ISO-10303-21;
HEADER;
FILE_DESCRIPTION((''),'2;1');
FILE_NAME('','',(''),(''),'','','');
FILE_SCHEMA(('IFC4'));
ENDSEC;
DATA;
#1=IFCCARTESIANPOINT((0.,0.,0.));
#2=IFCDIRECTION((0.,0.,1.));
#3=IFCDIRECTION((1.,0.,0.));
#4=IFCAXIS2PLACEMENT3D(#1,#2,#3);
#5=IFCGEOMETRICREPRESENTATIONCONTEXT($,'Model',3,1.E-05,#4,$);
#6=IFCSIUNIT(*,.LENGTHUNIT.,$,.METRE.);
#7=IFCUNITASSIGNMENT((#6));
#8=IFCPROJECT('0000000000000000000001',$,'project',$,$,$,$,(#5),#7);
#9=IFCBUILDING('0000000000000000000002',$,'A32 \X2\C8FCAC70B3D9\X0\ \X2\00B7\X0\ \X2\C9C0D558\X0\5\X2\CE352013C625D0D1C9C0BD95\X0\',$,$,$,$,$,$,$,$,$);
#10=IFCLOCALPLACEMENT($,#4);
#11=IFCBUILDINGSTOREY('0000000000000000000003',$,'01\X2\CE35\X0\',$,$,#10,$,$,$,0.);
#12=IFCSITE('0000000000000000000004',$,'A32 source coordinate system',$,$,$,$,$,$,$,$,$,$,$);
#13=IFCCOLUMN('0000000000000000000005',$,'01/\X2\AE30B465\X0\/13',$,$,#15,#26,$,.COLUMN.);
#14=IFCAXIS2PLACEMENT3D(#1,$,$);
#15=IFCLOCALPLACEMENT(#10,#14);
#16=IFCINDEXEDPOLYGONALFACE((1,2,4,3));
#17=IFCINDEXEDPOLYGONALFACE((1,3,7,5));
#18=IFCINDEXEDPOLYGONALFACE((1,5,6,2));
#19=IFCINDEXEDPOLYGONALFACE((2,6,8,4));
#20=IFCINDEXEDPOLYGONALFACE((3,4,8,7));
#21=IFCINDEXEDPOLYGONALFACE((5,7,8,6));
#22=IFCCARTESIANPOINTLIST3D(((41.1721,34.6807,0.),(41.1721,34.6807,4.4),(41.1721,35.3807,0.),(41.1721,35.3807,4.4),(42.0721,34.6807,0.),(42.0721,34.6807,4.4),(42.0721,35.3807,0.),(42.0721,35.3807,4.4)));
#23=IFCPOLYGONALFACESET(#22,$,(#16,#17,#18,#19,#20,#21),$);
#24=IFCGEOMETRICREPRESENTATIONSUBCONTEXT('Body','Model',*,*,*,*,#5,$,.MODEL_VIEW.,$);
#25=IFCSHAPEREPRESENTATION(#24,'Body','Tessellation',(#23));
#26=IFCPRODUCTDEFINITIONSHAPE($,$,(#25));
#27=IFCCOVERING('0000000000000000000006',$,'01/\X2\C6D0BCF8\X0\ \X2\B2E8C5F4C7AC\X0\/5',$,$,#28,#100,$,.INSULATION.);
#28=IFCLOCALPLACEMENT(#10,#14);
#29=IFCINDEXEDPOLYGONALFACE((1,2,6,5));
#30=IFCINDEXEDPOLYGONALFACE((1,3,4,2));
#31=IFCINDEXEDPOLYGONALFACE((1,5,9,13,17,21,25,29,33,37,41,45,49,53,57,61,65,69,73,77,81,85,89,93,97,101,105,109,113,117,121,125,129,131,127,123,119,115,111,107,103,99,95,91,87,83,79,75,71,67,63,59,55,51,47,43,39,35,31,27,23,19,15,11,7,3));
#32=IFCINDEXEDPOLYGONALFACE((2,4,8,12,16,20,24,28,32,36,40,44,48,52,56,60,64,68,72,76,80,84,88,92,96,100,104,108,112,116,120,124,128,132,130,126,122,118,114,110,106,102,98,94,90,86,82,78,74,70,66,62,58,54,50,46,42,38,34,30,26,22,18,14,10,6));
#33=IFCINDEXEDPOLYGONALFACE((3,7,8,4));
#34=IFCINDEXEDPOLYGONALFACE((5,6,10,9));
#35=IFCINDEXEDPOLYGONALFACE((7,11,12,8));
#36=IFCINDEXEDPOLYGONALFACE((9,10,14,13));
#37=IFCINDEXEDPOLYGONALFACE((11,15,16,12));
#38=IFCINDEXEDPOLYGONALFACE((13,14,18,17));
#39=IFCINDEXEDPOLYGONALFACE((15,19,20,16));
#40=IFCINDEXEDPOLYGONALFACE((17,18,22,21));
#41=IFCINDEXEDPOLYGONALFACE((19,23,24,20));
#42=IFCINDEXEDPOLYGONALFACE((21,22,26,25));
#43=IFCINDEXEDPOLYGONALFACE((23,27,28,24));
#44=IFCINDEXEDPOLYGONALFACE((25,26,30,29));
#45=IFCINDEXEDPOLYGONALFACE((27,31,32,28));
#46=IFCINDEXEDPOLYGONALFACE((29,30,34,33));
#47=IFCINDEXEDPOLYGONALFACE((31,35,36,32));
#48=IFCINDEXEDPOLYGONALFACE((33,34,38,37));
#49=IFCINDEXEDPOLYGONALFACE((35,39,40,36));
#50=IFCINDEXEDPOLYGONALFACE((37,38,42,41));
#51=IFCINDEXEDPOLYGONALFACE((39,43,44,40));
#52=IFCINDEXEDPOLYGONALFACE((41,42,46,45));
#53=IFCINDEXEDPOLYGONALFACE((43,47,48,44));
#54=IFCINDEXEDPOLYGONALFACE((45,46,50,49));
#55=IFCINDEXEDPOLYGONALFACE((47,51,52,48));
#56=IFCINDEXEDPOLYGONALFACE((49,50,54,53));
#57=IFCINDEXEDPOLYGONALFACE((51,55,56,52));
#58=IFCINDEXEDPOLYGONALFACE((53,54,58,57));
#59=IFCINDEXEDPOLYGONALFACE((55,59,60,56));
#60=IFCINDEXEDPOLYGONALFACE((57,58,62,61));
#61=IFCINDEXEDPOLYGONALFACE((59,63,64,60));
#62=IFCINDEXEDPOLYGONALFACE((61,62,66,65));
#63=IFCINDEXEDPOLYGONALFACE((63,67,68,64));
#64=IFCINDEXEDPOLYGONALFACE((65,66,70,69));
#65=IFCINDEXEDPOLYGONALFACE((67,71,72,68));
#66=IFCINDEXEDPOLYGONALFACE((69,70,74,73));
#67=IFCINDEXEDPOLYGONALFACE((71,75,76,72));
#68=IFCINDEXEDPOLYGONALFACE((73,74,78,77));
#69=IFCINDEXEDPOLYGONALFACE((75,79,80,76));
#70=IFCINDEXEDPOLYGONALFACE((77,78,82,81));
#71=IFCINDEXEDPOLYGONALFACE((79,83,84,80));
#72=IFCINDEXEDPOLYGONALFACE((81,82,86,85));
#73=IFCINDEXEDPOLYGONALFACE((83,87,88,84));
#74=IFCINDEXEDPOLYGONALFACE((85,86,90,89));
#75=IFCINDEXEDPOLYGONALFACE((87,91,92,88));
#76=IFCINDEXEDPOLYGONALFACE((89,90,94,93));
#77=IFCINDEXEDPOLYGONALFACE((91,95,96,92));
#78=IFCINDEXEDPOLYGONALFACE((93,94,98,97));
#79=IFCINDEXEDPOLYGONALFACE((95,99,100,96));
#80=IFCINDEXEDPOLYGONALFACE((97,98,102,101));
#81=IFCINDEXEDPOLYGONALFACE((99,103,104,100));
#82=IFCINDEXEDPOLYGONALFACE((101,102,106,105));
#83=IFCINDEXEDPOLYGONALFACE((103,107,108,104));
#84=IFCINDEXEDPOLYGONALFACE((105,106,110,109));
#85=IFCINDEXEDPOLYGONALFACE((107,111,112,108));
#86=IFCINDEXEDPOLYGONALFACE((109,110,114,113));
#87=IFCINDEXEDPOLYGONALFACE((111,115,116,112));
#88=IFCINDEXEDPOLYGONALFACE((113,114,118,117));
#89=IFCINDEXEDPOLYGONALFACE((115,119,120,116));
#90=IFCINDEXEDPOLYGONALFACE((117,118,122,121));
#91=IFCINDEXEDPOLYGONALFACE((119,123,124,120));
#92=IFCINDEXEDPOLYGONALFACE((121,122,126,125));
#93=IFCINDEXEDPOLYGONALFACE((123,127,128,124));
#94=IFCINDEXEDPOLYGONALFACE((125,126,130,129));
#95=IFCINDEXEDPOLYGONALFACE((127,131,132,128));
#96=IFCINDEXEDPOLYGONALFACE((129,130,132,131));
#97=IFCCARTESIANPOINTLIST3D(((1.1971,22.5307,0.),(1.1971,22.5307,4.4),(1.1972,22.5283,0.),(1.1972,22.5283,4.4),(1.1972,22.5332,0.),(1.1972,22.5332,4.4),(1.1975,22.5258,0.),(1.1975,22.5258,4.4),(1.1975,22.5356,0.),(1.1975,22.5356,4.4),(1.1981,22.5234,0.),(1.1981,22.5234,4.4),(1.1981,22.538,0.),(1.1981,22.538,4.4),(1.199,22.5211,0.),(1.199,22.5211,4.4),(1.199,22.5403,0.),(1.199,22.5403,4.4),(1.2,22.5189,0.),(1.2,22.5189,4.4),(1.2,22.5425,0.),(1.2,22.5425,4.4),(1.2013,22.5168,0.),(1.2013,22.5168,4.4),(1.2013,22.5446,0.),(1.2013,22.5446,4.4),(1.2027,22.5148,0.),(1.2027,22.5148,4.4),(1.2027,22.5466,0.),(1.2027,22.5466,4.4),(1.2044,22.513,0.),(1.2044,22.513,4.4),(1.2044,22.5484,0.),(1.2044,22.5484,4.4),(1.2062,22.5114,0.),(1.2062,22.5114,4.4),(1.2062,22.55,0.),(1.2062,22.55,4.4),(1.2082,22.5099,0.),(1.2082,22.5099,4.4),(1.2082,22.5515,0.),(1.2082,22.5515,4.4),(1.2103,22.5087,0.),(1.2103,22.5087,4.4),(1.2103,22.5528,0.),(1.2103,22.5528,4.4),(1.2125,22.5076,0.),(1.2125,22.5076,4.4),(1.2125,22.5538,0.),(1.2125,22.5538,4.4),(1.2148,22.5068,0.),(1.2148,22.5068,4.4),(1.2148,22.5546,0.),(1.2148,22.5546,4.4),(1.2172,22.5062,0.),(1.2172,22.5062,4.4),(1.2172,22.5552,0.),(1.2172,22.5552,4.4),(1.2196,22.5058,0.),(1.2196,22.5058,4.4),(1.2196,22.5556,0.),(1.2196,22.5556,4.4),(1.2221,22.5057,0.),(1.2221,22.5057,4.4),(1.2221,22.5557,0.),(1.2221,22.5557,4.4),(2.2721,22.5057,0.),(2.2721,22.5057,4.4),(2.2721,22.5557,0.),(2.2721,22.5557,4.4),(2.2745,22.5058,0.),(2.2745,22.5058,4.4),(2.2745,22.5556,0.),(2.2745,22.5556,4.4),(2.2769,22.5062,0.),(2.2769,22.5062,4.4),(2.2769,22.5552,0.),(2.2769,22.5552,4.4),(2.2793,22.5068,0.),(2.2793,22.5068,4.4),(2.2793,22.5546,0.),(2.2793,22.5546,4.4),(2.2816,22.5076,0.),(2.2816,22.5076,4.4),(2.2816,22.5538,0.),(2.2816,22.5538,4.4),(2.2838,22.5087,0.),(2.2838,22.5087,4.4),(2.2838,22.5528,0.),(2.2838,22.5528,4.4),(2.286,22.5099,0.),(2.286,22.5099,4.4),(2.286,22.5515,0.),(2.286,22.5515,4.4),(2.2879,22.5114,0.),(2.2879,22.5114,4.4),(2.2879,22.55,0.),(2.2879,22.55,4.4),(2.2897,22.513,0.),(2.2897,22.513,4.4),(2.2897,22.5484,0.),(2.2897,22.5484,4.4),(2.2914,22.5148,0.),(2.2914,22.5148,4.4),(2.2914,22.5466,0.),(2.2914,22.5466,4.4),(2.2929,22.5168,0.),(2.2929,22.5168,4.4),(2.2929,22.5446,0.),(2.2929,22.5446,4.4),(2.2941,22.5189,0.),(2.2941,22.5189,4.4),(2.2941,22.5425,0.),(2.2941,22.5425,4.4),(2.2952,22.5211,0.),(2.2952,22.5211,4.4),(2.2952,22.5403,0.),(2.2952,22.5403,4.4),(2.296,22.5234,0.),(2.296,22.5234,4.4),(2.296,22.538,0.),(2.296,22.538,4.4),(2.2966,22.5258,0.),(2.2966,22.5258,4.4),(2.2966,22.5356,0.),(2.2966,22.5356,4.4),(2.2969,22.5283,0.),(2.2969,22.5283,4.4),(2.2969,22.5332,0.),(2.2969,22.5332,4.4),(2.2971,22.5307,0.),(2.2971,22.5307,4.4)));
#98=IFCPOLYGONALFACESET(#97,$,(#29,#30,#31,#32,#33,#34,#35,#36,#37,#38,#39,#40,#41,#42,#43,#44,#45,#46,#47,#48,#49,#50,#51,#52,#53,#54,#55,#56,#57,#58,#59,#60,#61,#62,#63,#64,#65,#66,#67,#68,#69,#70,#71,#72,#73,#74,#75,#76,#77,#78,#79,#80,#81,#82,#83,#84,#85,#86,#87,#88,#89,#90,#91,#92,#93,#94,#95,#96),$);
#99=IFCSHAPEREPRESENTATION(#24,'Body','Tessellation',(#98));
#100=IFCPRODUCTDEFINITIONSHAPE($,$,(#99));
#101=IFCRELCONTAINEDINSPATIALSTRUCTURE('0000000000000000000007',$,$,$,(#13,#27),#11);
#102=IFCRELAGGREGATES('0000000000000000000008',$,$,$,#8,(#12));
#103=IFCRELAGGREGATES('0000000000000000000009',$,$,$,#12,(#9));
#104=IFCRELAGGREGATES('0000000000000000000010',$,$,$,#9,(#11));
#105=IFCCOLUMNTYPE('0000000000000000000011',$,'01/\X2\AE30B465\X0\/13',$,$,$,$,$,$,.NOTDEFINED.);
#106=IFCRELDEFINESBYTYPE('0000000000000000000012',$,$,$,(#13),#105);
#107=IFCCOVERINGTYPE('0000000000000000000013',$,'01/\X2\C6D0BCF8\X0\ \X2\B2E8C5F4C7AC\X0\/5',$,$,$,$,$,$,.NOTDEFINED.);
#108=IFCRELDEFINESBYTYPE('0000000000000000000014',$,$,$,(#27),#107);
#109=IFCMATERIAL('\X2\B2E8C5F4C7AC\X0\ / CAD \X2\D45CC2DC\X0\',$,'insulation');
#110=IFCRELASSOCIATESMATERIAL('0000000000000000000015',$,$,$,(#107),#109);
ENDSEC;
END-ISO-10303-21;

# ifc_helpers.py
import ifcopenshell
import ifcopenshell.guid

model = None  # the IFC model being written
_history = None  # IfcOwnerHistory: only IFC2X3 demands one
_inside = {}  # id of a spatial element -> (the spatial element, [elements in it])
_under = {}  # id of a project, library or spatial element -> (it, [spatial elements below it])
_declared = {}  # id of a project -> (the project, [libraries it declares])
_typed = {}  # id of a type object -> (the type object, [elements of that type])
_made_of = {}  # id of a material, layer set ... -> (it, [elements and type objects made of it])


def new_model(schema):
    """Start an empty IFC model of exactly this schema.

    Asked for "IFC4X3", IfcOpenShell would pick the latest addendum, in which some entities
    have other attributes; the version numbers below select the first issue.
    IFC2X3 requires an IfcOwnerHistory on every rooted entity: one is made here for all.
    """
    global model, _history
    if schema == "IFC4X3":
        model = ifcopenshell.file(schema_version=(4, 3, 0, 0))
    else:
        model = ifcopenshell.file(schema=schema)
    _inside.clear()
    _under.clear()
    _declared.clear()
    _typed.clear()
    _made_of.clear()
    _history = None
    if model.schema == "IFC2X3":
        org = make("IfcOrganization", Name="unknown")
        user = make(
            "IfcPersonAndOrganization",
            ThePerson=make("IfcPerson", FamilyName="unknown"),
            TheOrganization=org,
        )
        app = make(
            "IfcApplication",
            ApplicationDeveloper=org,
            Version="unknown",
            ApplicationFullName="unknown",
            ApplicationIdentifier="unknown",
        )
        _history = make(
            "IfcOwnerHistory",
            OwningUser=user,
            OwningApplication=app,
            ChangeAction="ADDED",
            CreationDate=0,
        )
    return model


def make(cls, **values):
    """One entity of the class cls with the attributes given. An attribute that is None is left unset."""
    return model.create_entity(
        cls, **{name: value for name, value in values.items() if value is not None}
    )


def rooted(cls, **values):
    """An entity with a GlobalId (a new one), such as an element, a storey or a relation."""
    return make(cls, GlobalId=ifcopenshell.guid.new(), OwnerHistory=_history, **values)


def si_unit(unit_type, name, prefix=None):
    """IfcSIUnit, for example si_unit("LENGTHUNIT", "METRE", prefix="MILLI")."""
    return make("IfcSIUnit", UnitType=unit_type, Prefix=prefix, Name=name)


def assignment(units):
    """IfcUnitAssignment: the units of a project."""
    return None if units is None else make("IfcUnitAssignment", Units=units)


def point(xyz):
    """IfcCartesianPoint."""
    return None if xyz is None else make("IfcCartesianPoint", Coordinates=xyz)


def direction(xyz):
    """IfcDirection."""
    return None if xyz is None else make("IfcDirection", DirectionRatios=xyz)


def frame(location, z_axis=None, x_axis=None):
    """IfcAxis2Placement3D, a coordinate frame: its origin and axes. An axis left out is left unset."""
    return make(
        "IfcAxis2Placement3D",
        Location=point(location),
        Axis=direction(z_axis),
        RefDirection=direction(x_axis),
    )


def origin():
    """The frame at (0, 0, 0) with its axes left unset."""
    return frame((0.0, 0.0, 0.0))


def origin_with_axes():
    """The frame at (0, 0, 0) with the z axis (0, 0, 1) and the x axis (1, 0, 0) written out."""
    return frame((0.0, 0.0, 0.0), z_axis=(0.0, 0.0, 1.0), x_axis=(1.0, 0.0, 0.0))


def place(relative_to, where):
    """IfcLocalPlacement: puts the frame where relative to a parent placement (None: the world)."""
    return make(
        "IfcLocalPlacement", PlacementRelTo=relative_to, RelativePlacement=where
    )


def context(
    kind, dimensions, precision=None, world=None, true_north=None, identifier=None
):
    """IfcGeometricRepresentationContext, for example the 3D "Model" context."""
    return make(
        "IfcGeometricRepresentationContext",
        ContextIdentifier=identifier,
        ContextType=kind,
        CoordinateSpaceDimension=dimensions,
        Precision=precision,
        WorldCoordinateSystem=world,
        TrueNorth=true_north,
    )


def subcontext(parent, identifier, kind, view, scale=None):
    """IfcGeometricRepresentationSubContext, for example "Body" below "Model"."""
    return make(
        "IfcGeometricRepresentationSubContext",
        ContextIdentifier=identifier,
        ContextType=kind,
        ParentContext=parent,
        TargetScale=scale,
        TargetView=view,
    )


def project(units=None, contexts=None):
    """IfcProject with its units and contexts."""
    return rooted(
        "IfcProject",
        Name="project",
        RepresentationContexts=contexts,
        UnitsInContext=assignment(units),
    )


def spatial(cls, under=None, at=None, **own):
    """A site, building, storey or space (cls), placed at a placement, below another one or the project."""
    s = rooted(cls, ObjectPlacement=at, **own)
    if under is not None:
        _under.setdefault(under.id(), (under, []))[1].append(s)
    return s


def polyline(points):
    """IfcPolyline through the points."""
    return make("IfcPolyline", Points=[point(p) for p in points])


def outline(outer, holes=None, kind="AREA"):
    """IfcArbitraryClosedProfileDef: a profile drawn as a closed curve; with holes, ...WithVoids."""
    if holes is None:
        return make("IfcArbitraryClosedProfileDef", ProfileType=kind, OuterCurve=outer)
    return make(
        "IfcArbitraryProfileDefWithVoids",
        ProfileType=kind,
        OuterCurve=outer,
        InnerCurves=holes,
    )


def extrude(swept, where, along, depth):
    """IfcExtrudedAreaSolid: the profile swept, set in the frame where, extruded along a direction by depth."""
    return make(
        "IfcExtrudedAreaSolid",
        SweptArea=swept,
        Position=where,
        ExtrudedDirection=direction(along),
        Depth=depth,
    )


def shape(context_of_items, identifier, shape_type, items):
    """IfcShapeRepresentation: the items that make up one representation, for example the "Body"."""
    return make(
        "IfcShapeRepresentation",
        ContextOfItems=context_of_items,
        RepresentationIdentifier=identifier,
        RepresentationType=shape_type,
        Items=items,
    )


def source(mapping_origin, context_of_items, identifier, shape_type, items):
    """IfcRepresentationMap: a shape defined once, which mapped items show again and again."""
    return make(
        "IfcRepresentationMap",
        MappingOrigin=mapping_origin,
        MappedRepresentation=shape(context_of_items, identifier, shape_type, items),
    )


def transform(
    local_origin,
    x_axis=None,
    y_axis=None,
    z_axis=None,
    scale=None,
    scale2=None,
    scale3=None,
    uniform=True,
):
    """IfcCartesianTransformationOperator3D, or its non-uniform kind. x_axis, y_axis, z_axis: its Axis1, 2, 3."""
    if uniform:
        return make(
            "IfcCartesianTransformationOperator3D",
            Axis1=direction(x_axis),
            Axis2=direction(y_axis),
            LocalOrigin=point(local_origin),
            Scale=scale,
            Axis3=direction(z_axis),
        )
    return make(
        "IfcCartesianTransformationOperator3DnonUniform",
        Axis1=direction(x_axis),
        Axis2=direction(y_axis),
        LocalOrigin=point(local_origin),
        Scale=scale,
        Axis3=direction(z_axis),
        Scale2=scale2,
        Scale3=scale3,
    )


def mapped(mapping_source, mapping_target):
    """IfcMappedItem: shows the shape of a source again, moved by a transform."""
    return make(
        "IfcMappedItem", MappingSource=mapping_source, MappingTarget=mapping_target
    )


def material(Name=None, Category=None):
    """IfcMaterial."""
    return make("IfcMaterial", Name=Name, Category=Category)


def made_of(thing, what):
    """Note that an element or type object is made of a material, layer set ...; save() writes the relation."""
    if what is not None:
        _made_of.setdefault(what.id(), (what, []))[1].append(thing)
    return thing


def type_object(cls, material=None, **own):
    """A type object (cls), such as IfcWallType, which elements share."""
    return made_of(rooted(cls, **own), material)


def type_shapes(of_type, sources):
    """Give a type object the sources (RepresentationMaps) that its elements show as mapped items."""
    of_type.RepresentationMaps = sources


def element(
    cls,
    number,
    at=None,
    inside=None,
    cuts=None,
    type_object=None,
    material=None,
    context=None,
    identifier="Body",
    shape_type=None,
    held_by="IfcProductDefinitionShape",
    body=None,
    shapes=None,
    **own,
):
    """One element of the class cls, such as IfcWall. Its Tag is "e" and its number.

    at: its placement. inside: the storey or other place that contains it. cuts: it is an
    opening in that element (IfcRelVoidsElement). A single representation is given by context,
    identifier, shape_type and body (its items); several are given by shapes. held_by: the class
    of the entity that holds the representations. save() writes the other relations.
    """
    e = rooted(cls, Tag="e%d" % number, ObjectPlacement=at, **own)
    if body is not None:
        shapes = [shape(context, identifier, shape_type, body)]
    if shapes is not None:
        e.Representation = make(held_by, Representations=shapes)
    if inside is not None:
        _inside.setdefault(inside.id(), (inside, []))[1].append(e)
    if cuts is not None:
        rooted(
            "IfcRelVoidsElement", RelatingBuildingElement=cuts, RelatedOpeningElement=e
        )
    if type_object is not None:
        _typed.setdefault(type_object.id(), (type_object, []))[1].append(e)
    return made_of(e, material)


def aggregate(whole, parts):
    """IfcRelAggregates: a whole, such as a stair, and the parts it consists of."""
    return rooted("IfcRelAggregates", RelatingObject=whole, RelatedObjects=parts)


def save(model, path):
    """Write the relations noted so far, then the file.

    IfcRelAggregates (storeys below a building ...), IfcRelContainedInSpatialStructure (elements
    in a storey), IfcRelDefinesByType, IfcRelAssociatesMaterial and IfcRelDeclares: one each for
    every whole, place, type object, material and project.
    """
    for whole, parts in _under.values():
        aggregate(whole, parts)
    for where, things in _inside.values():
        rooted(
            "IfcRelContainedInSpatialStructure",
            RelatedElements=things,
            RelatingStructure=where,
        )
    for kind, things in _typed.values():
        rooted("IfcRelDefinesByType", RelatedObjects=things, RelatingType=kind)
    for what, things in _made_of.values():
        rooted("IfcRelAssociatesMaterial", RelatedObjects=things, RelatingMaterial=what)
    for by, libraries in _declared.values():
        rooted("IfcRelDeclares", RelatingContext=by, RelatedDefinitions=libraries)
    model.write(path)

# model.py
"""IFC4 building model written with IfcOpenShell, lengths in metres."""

from ifc_helpers import new_model, si_unit, origin, origin_with_axes, place, context, subcontext, project, spatial, polyline, outline, extrude, source, transform, mapped, material, type_object, type_shapes, element, save


model = new_model("IFC4")

# Units and contexts
model_context = context("Model", 3, precision=1e-05, world=origin_with_axes())
body_context = subcontext(model_context, "Body", "Model", "MODEL_VIEW")
ifc_project = project(units=[si_unit("LENGTHUNIT", "METRE")], contexts=[model_context])

# Site, building, storey
site = spatial("IfcSite", under=ifc_project, Name="A32 source coordinate system")
building = spatial("IfcBuilding", under=site, Name="A32 주거동 · 지하5층–옥탑지붕")
storey_placement = place(None, origin_with_axes())
storey = spatial("IfcBuildingStorey", under=building, at=storey_placement, Name="01층", Elevation=0.0)

# Column
column_type_1 = type_object("IfcColumnType", Name="01/기둥/13", PredefinedType="NOTDEFINED")
shared_shape_1 = source(origin(), body_context, "Body", "SweptSolid", [
    extrude(outline(polyline([(41.1721, 34.6807), (41.1721, 35.3807), (42.0721, 35.3807), (42.0721, 34.6807), (41.1721, 34.6807)])), origin(), (0.0, 0.0, 1.0), 4.4),
])
type_shapes(column_type_1, [shared_shape_1])
column_1_placement = place(storey_placement, origin_with_axes())
element("IfcColumn", 1, at=column_1_placement, inside=storey, type_object=column_type_1, Name="01/기둥/13", PredefinedType="COLUMN", context=body_context, shape_type="MappedRepresentation", body=[
    mapped(shared_shape_1, transform((0.0, 0.0, 0.0), scale=1.0)),
])

# Covering
ifc_material = material(Name="단열재 / CAD 표시", Category="insulation")
covering_type_1 = type_object("IfcCoveringType", Name="01/원본 단열재/5", PredefinedType="NOTDEFINED", material=ifc_material)
shared_shape_2 = source(origin(), body_context, "Body", "SweptSolid", [
    extrude(outline(polyline([(2.2838, 22.5528), (2.286, 22.5515), (2.2879, 22.55), (2.2897, 22.5484), (2.2914, 22.5466), (2.2929, 22.5446), (2.2941, 22.5425), (2.2952, 22.5403), (2.296, 22.538), (2.2966, 22.5356), (2.2969, 22.5332), (2.2971, 22.5307), (2.2969, 22.5283), (2.2966, 22.5258), (2.296, 22.5234), (2.2952, 22.5211), (2.2941, 22.5189), (2.2929, 22.5168), (2.2914, 22.5148), (2.2897, 22.513), (2.2879, 22.5114), (2.286, 22.5099), (2.2838, 22.5087), (2.2816, 22.5076), (2.2793, 22.5068), (2.2769, 22.5062), (2.2745, 22.5058), (2.2721, 22.5057), (1.2221, 22.5057), (1.2196, 22.5058), (1.2172, 22.5062), (1.2148, 22.5068), (1.2125, 22.5076), (1.2103, 22.5087), (1.2082, 22.5099), (1.2062, 22.5114), (1.2044, 22.513), (1.2027, 22.5148), (1.2013, 22.5168), (1.2, 22.5189), (1.199, 22.5211), (1.1981, 22.5234), (1.1975, 22.5258), (1.1972, 22.5283), (1.1971, 22.5307), (1.1972, 22.5332), (1.1975, 22.5356), (1.1981, 22.538), (1.199, 22.5403), (1.2, 22.5425), (1.2013, 22.5446), (1.2027, 22.5466), (1.2044, 22.5484), (1.2062, 22.55), (1.2082, 22.5515), (1.2103, 22.5528), (1.2125, 22.5538), (1.2148, 22.5546), (1.2172, 22.5552), (1.2196, 22.5556), (1.2221, 22.5557), (2.2721, 22.5557), (2.2745, 22.5556), (2.2769, 22.5552), (2.2793, 22.5546), (2.2816, 22.5538), (2.2838, 22.5528)])), origin(), (0.0, 0.0, 1.0), 4.4),
])
type_shapes(covering_type_1, [shared_shape_2])
covering_1_placement = place(storey_placement, origin_with_axes())
element("IfcCovering", 2, at=covering_1_placement, inside=storey, type_object=covering_type_1, Name="01/원본 단열재/5", PredefinedType="INSULATION", context=body_context, shape_type="MappedRepresentation", body=[
    mapped(shared_shape_2, transform((0.0, 0.0, 0.0), scale=1.0)),
])

save(model, "model.ifc")
